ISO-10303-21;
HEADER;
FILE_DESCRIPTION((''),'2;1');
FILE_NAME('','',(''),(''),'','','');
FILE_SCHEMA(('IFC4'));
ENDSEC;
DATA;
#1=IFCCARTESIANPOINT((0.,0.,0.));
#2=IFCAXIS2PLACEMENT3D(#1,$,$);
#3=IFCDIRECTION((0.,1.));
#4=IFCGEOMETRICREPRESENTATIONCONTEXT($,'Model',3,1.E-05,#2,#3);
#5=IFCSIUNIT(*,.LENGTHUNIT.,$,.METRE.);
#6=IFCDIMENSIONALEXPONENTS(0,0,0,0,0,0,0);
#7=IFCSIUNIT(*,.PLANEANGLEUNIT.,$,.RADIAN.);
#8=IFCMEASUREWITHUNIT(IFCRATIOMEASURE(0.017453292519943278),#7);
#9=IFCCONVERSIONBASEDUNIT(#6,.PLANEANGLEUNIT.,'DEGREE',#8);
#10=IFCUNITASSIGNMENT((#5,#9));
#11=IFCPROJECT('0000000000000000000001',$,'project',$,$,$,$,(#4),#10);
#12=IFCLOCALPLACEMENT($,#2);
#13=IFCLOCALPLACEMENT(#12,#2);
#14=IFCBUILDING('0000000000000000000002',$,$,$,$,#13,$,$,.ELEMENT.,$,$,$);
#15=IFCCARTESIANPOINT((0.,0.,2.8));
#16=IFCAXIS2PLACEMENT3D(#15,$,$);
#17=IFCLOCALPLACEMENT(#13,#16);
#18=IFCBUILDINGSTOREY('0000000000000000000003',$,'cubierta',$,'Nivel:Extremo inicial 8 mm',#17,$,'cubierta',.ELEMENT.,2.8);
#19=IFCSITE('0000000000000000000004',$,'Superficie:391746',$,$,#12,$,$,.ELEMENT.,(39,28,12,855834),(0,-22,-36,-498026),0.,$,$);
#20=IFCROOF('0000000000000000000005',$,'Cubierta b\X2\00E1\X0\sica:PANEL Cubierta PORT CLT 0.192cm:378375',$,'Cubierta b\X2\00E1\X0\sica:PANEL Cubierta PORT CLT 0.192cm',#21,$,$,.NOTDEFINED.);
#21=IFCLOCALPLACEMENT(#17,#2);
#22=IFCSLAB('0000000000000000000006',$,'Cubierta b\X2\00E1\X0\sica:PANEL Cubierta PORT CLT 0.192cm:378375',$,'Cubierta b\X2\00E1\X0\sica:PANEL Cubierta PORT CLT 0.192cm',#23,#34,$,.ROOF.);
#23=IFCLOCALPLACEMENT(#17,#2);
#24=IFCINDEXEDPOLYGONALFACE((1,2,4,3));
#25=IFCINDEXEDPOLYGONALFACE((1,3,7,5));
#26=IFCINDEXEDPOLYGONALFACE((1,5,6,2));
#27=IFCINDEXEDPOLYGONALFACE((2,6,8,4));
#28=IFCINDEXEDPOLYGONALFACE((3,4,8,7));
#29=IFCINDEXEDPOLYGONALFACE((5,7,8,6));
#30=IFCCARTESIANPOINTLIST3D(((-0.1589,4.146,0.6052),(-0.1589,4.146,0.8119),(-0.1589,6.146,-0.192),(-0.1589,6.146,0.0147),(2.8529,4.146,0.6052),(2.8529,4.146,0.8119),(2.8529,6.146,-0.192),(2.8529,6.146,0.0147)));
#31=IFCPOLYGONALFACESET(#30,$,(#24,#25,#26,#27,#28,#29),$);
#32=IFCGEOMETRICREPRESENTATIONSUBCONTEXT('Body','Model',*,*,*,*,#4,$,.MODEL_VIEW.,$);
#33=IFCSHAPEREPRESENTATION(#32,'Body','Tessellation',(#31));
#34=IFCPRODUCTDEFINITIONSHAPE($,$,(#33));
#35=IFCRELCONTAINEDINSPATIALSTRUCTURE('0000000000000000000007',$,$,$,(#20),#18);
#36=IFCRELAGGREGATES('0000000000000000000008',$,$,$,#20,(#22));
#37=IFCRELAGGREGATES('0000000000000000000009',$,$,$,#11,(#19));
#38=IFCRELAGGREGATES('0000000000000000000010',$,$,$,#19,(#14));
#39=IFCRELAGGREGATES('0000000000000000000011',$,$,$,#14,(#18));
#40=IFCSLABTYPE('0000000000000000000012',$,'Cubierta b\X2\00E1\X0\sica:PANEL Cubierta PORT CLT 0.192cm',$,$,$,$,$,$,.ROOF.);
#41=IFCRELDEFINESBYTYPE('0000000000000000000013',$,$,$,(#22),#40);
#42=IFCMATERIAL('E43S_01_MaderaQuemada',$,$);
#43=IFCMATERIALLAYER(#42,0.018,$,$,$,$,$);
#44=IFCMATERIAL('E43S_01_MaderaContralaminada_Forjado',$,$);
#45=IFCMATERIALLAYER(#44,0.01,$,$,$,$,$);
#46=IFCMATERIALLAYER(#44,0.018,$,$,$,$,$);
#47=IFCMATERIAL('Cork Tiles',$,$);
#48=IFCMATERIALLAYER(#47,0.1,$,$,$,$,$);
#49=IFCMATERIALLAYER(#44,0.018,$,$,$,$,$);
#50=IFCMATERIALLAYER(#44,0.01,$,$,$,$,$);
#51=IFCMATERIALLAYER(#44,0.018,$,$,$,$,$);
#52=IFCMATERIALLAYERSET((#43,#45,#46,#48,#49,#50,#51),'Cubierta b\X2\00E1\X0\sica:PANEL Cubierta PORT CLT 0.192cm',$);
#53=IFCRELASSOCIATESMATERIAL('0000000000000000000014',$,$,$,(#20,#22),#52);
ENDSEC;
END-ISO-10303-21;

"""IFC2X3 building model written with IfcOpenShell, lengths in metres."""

from ifc_helpers import new_model, entity, si_unit, converted_unit, direction, frame, frame_2d, origin, place, context, subcontext, project, spatial, rectangle, extrude, material, layer, layer_set, type_object, element, aggregate, save


model = new_model("IFC2X3")

# Units and contexts
model_context = context("Model", 3, precision=1e-05, world=origin(), true_north=direction((0.0, 1.0)))
body_context = subcontext(model_context, "Body", "Model", "MODEL_VIEW")
ifc_project = project(units=[si_unit("LENGTHUNIT", "METRE"), converted_unit("PLANEANGLEUNIT", "DEGREE", entity("IfcRatioMeasure", 0.017453292519943278), si_unit("PLANEANGLEUNIT", "RADIAN"), dimensions=[0, 0, 0, 0, 0, 0, 0])], contexts=[model_context])

# Site, building, storey
site_placement = place(None, origin())
site = spatial("IfcSite", under=ifc_project, at=site_placement, Name="Superficie:391746", CompositionType="ELEMENT", RefLatitude=(39, 28, 12, 855834), RefLongitude=(0, -22, -36, -498026), RefElevation=0.0)
building_placement = place(site_placement, origin())
building = spatial("IfcBuilding", under=site, at=building_placement, CompositionType="ELEMENT")
storey_placement = place(building_placement, frame((0.0, 0.0, 2.8)))
storey = spatial("IfcBuildingStorey", under=building, at=storey_placement, Name="cubierta", ObjectType="Nivel:Extremo inicial 8 mm", LongName="cubierta", CompositionType="ELEMENT", Elevation=2.8)

# Roof, slab
ifc_material_1 = material(Name="E43S_01_MaderaQuemada")
ifc_layer_1 = layer(ifc_material_1, 0.018)
ifc_material_2 = material(Name="E43S_01_MaderaContralaminada_Forjado")
ifc_layer_2 = layer(ifc_material_2, 0.01)
ifc_layer_3 = layer(ifc_material_2, 0.018)
ifc_material_3 = material(Name="Cork Tiles")
ifc_layer_4 = layer(ifc_material_3, 0.1)
ifc_layer_5 = layer(ifc_material_2, 0.018)
ifc_layer_6 = layer(ifc_material_2, 0.01)
ifc_layer_7 = layer(ifc_material_2, 0.018)
ifc_layer_set = layer_set([ifc_layer_1, ifc_layer_2, ifc_layer_3, ifc_layer_4, ifc_layer_5, ifc_layer_6, ifc_layer_7], Name="Cubierta básica:PANEL Cubierta PORT CLT 0.192cm")
roof_placement = place(storey_placement, frame((-0.1589, 4.146, -0.192)))
roof = element("IfcRoof", 1, at=roof_placement, inside=storey, material=ifc_layer_set, Name="Cubierta básica:PANEL Cubierta PORT CLT 0.192cm:378375", ObjectType="Cubierta básica:PANEL Cubierta PORT CLT 0.192cm", ShapeType="NOTDEFINED")
slab_type = type_object("IfcSlabType", Name="Cubierta básica:PANEL Cubierta PORT CLT 0.192cm", PredefinedType="ROOF")
slab_placement = place(roof_placement, origin())
slab = element("IfcSlab", 2, at=slab_placement, type_object=slab_type, material=ifc_layer_set, Name="Cubierta básica:PANEL Cubierta PORT CLT 0.192cm:378375", ObjectType="Cubierta básica:PANEL Cubierta PORT CLT 0.192cm", PredefinedType="ROOF", context=body_context, shape_type="SweptSolid", body=[
    extrude(rectangle(XDim=2.153, YDim=3.0118, at=frame_2d((0.0, 0.0), x_axis=(0.0, 1.0))), frame((1.5059, 1.0, 0.3986), z_axis=(0.0, 0.370288, 0.928917), x_axis=(1.0, 0.0, 0.0)), (0.0, -0.370288, 0.928917), 0.2067),
])
aggregate(roof, [slab])

save(model, "model.ifc")
